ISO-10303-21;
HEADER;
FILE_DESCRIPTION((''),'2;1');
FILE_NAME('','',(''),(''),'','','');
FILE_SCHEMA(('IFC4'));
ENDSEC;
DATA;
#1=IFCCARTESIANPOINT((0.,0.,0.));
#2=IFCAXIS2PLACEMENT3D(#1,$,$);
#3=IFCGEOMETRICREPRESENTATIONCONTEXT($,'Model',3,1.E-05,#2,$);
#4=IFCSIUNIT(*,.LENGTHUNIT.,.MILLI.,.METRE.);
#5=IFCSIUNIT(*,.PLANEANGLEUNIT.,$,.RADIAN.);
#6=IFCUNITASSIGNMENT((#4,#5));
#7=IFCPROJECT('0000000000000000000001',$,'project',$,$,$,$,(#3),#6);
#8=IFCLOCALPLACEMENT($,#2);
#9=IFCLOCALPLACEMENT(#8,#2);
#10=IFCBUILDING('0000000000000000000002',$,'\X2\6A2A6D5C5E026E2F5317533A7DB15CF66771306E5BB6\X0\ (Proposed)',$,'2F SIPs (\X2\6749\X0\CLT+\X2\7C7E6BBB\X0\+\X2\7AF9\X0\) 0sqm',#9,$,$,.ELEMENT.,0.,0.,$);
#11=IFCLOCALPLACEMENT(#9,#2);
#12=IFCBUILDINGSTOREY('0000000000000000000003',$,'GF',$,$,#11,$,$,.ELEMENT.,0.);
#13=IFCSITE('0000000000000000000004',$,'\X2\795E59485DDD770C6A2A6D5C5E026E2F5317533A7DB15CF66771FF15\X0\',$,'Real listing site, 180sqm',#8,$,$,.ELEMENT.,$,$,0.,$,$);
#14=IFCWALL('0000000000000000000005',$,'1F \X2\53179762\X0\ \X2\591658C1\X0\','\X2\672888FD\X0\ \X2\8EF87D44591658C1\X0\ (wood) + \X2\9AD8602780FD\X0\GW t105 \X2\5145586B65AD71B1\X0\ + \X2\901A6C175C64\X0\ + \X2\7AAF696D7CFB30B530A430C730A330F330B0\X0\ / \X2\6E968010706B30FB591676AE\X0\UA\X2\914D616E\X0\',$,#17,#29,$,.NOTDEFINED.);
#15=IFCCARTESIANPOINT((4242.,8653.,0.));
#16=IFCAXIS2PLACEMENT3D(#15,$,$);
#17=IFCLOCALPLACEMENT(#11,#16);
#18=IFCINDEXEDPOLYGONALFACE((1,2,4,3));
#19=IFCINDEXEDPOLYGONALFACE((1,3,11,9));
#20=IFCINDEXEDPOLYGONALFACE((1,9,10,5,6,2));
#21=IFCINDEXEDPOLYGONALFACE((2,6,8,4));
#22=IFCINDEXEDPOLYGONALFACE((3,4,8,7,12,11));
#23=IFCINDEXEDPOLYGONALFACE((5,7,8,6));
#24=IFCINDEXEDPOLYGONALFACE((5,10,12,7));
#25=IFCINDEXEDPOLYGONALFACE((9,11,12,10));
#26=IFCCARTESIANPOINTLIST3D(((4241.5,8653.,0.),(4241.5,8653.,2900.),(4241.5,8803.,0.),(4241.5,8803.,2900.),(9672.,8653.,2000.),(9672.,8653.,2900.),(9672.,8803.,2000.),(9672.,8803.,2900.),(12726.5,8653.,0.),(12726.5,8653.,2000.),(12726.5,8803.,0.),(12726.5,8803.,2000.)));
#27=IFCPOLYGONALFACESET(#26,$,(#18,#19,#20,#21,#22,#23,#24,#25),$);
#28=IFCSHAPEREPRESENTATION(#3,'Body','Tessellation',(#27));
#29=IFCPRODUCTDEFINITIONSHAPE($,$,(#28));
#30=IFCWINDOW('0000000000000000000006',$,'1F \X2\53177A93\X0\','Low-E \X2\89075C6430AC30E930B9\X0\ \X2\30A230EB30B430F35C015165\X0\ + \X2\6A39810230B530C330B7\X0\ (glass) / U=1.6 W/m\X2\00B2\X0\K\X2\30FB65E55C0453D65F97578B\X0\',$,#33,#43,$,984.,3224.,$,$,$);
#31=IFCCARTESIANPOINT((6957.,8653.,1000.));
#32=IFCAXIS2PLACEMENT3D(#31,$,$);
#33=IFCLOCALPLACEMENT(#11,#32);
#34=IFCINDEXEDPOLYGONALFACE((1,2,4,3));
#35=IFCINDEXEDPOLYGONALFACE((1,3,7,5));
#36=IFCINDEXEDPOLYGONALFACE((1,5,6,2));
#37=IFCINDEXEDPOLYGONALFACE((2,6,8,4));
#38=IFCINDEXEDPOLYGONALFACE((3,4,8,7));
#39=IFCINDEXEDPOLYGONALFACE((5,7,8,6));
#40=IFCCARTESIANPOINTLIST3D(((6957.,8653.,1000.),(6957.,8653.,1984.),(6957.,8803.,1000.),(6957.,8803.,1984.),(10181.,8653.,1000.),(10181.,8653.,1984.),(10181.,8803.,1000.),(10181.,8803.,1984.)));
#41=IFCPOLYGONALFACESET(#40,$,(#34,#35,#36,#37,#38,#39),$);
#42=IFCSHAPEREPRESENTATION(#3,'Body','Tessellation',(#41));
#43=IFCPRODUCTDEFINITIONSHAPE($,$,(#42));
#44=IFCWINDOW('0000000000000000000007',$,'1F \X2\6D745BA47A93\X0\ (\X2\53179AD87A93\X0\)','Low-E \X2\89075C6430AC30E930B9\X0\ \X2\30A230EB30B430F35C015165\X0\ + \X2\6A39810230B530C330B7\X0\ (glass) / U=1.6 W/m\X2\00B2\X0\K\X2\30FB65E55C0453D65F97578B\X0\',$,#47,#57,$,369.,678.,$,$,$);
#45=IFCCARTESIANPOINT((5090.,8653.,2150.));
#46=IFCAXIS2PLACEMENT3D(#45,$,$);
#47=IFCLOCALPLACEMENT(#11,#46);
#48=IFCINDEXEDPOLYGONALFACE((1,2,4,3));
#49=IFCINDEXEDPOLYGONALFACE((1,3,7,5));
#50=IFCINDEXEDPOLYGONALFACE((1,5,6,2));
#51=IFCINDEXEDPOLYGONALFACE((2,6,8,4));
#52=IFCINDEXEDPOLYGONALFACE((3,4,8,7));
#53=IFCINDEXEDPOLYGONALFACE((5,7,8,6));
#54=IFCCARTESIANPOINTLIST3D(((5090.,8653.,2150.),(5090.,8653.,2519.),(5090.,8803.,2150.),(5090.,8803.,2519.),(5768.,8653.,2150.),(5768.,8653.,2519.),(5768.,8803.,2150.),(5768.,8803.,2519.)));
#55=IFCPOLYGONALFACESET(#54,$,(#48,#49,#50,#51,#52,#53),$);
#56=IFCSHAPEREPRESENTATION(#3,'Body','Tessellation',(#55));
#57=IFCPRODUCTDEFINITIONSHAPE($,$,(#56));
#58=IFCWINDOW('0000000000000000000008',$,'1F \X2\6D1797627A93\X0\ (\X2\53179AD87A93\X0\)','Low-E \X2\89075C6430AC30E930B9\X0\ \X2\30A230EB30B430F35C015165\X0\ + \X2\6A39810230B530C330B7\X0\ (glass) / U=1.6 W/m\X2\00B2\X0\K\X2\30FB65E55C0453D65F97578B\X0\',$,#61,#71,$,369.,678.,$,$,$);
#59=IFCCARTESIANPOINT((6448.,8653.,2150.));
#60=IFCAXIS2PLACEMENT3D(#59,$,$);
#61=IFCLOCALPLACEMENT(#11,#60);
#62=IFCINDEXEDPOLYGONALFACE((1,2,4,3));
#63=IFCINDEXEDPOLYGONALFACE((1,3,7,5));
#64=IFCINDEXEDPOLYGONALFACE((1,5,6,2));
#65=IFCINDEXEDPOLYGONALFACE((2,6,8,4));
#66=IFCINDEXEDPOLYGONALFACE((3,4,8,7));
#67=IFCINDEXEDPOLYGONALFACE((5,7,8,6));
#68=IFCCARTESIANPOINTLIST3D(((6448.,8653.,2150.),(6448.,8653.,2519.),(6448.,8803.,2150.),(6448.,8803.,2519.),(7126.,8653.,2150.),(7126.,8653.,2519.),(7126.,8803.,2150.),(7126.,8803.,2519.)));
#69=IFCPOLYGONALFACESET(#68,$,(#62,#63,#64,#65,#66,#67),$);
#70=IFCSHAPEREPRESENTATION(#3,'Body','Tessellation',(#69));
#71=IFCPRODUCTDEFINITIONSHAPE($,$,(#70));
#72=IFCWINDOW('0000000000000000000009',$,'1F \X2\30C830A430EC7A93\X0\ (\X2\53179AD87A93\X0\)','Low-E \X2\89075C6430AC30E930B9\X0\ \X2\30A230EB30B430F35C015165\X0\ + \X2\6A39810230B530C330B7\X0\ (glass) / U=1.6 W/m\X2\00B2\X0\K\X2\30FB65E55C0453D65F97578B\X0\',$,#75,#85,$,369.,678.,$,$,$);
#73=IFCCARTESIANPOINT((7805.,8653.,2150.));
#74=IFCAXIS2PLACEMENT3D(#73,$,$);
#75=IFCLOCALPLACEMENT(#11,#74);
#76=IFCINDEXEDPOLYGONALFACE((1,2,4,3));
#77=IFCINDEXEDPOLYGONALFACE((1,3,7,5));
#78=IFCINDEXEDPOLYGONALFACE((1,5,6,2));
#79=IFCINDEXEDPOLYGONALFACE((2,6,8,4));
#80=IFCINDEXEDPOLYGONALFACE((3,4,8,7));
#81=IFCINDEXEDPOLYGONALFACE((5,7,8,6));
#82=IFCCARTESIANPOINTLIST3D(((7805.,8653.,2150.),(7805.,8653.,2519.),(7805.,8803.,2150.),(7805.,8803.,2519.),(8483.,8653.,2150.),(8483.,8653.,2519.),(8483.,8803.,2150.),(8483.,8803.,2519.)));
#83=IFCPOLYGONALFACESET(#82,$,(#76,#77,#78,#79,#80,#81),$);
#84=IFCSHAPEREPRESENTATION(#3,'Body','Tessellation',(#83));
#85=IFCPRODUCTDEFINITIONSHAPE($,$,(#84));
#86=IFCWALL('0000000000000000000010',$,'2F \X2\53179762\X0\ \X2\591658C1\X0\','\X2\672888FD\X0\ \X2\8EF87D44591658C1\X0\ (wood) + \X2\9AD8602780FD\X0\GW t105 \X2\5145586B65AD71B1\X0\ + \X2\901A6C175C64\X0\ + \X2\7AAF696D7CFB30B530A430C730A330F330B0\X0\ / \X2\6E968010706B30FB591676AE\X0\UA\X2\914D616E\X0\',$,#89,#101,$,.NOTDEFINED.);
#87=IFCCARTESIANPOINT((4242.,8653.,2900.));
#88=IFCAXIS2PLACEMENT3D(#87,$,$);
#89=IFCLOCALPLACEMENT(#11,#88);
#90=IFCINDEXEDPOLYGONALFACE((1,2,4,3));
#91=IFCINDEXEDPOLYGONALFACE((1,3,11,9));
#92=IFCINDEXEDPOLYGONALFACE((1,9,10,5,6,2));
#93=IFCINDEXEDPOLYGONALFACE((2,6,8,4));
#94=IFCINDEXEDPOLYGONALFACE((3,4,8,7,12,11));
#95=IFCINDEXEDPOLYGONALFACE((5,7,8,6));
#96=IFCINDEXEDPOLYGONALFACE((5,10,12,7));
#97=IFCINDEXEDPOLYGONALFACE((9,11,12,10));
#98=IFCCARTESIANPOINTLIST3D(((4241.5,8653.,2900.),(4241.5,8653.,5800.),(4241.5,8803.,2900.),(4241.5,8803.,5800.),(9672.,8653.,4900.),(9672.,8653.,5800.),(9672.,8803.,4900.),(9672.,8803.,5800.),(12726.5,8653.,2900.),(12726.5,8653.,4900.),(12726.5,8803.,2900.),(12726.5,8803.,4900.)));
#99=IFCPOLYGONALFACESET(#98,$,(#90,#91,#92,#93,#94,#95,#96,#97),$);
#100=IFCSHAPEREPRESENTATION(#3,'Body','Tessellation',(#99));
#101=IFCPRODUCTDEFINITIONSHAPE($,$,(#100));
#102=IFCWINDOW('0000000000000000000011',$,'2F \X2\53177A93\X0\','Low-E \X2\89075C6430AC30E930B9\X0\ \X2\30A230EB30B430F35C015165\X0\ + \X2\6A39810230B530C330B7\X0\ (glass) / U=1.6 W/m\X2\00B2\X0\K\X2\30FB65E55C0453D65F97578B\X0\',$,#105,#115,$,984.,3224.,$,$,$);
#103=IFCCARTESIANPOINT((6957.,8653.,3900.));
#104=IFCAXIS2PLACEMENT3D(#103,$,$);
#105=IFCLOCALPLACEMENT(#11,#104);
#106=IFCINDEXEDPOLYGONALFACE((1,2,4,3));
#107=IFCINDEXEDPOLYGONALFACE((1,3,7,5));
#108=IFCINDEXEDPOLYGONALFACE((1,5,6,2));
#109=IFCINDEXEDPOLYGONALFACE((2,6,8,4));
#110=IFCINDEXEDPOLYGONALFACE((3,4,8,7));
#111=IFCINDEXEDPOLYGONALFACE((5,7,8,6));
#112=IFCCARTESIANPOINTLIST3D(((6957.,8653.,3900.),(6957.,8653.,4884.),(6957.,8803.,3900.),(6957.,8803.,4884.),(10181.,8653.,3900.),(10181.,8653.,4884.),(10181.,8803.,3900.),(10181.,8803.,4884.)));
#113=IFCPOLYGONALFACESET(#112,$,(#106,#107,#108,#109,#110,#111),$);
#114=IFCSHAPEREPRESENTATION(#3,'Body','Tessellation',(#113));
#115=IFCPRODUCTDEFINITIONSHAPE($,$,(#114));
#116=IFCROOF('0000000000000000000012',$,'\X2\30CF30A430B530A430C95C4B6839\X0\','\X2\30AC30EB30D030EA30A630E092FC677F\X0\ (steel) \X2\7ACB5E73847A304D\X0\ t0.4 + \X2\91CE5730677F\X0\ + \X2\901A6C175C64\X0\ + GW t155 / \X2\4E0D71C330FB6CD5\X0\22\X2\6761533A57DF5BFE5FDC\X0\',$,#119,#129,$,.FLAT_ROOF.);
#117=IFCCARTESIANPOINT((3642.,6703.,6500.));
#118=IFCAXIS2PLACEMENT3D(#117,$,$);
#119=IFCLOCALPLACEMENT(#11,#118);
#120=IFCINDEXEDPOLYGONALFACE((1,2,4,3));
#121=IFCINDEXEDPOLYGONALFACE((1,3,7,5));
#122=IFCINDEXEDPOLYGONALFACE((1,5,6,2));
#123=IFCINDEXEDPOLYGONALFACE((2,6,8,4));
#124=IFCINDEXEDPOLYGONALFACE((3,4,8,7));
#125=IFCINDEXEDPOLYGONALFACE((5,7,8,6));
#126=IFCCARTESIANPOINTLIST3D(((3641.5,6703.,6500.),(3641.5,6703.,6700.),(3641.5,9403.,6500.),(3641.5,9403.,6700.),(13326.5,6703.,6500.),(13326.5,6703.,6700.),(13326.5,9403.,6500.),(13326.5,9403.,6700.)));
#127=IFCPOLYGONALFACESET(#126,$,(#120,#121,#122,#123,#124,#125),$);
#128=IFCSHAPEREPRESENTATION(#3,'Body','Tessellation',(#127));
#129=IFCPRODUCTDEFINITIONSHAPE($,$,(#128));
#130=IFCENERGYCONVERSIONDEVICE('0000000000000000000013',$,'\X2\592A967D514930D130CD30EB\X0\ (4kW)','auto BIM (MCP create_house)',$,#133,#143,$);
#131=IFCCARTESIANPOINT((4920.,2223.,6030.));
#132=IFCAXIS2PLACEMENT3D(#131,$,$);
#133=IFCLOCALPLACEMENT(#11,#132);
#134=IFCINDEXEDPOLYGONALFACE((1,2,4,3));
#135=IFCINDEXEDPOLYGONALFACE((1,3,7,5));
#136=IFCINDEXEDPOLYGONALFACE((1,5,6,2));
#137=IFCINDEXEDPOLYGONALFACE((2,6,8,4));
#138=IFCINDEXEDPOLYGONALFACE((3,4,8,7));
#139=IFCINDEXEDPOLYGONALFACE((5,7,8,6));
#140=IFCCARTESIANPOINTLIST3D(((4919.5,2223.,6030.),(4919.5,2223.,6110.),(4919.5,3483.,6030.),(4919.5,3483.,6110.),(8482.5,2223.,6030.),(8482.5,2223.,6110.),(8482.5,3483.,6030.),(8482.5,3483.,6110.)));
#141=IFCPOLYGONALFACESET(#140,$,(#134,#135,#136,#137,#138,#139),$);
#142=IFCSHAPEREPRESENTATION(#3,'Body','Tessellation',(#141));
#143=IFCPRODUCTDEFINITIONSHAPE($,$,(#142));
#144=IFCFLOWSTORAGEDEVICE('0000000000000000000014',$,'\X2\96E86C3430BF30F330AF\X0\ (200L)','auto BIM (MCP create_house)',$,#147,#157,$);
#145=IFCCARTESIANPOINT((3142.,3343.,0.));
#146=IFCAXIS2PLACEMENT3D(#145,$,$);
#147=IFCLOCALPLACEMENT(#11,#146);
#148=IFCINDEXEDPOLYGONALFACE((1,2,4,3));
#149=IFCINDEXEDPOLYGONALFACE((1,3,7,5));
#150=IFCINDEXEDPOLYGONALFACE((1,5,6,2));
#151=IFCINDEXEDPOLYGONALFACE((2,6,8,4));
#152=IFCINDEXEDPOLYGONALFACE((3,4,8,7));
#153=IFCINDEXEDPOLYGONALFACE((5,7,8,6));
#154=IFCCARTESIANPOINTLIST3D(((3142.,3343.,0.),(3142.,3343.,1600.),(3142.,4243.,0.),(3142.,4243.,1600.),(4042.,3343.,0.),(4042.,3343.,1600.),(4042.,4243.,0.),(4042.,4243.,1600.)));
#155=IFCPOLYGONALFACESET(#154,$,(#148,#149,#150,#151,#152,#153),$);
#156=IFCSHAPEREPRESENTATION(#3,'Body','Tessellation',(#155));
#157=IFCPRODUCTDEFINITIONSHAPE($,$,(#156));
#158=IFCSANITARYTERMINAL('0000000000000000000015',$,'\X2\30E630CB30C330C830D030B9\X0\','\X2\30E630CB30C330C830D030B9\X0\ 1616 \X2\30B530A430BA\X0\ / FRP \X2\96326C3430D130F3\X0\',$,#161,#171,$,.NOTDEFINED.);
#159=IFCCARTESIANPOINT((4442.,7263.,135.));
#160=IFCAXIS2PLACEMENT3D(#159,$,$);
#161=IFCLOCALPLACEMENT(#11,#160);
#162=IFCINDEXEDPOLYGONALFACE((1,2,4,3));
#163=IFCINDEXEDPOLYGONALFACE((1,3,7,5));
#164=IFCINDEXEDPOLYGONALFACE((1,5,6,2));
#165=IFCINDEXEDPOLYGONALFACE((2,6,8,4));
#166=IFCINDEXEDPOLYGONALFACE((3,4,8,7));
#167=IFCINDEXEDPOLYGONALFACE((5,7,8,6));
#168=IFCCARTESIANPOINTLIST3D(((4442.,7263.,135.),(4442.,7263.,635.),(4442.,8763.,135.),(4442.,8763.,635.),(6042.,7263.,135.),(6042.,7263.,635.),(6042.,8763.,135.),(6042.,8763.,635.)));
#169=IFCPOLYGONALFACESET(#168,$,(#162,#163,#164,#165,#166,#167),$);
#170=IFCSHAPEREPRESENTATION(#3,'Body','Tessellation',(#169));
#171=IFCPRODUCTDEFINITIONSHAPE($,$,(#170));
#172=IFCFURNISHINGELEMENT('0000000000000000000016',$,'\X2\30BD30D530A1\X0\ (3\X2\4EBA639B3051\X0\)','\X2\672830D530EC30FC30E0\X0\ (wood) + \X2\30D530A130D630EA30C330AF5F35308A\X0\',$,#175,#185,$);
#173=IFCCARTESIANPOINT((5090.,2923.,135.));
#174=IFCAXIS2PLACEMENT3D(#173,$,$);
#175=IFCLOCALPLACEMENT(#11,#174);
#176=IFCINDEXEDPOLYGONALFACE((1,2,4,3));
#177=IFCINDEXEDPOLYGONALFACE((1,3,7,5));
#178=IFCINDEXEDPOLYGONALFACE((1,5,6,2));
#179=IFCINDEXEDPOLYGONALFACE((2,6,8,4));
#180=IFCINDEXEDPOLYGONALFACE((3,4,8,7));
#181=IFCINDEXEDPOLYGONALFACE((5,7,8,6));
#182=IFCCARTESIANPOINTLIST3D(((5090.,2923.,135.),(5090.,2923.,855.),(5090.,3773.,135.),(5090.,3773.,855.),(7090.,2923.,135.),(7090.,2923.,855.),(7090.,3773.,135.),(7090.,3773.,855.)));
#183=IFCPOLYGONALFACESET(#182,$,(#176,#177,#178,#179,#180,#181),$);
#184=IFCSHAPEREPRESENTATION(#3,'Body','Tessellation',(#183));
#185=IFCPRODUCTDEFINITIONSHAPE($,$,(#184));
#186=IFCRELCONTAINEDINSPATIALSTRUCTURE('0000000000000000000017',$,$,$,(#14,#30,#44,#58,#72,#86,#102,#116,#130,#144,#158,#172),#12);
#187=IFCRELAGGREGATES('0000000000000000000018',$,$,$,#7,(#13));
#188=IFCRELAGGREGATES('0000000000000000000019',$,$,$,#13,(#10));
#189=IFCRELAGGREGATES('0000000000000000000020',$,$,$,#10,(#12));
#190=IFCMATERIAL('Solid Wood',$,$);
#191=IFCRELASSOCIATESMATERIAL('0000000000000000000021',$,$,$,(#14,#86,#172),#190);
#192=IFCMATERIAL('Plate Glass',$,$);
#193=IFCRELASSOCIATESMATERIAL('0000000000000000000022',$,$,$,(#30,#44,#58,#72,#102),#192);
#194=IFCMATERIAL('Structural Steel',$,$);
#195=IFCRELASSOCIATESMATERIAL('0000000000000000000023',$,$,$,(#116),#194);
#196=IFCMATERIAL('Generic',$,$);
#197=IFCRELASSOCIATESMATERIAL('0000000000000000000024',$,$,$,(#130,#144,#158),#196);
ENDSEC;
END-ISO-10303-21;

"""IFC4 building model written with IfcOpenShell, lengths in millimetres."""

from ifc_helpers import new_model, si_unit, frame, frame_2d, origin, place, context, project, spatial, rectangle, extrude, material, element, fill, save


model = new_model("IFC4")

# Units and contexts
model_context = context("Model", 3, precision=1e-05, world=origin())
ifc_project = project(units=[si_unit("LENGTHUNIT", "METRE", prefix="MILLI"), si_unit("PLANEANGLEUNIT", "RADIAN")], contexts=[model_context])

# Site, building, storey
site_placement = place(None, origin())
site = spatial("IfcSite", under=ifc_project, at=site_placement, Name="神奈川県横浜市港北区綱島東５", ObjectType="Real listing site, 180sqm", CompositionType="ELEMENT", RefElevation=0.0)
building_placement = place(site_placement, origin())
building = spatial("IfcBuilding", under=site, at=building_placement, Name="横浜市港北区綱島東の家 (Proposed)", ObjectType="2F SIPs (杉CLT+籾殻+竹) 0sqm", CompositionType="ELEMENT", ElevationOfRefHeight=0.0, ElevationOfTerrain=0.0)
storey_placement = place(building_placement, origin())
storey = spatial("IfcBuildingStorey", under=building, at=storey_placement, Name="GF", CompositionType="ELEMENT", Elevation=0.0)

# Wall, openings, windows
ifc_material_1 = material(Name="Solid Wood")
wall_1_placement = place(storey_placement, frame((4242.0, 8653.0, 0.0)))
wall_1 = element("IfcWall", 1, at=wall_1_placement, inside=storey, material=ifc_material_1, Name="1F 北面 外壁", Description="木製 軸組外壁 (wood) + 高性能GW t105 充填断熱 + 通気層 + 窯業系サイディング / 準耐火・外皮UA配慮", PredefinedType="NOTDEFINED", context=model_context, shape_type="SweptSolid", body=[
    extrude(rectangle(XDim=8485.0, YDim=150.0, at=frame_2d((4242.0, 75.0))), frame((4242.0, 8653.0, 0.0)), (0.0, 0.0, 1.0), 2900.0),
])
opening_1_placement = place(storey_placement, frame((6957.0, 8653.0, 1000.0)))
opening_1 = element("IfcOpeningElement", 2, at=opening_1_placement, cuts=wall_1, PredefinedType="NOTDEFINED", context=model_context, shape_type="SweptSolid", body=[
    extrude(rectangle(XDim=3224.0, YDim=150.0, at=frame_2d((1612.0, 75.0))), frame((6957.0, 8653.0, 1000.0)), (0.0, 0.0, 1.0), 984.0),
])
opening_2_placement = place(storey_placement, frame((5090.0, 8653.0, 2150.0)))
opening_2 = element("IfcOpeningElement", 3, at=opening_2_placement, cuts=wall_1, PredefinedType="NOTDEFINED", context=model_context, shape_type="SweptSolid", body=[
    extrude(rectangle(XDim=678.0, YDim=150.0, at=frame_2d((339.0, 75.0))), frame((5090.0, 8653.0, 2150.0)), (0.0, 0.0, 1.0), 369.0),
])
opening_3_placement = place(storey_placement, frame((6448.0, 8653.0, 2150.0)))
opening_3 = element("IfcOpeningElement", 4, at=opening_3_placement, cuts=wall_1, PredefinedType="NOTDEFINED", context=model_context, shape_type="SweptSolid", body=[
    extrude(rectangle(XDim=678.0, YDim=150.0, at=frame_2d((339.0, 75.0))), frame((6448.0, 8653.0, 2150.0)), (0.0, 0.0, 1.0), 369.0),
])
opening_4_placement = place(storey_placement, frame((7805.0, 8653.0, 2150.0)))
opening_4 = element("IfcOpeningElement", 5, at=opening_4_placement, cuts=wall_1, PredefinedType="NOTDEFINED", context=model_context, shape_type="SweptSolid", body=[
    extrude(rectangle(XDim=678.0, YDim=150.0, at=frame_2d((339.0, 75.0))), frame((7805.0, 8653.0, 2150.0)), (0.0, 0.0, 1.0), 369.0),
])
ifc_material_2 = material(Name="Plate Glass")
window_1_placement = place(storey_placement, frame((6957.0, 8653.0, 1000.0)))
window_1 = element("IfcWindow", 6, at=window_1_placement, inside=storey, material=ifc_material_2, Name="1F 北窓", Description="Low-E 複層ガラス アルゴン封入 + 樹脂サッシ (glass) / U=1.6 W/m²K・日射取得型", OverallHeight=984.0, OverallWidth=3224.0, context=model_context, shape_type="SweptSolid", body=[
    extrude(rectangle(XDim=3224.0, YDim=150.0, at=frame_2d((1612.0, 75.0))), frame((6957.0, 8653.0, 1000.0)), (0.0, 0.0, 1.0), 984.0),
])
fill(opening_1, window_1)
window_2_placement = place(storey_placement, frame((5090.0, 8653.0, 2150.0)))
window_2 = element("IfcWindow", 7, at=window_2_placement, inside=storey, material=ifc_material_2, Name="1F 浴室窓 (北高窓)", Description="Low-E 複層ガラス アルゴン封入 + 樹脂サッシ (glass) / U=1.6 W/m²K・日射取得型", OverallHeight=369.0, OverallWidth=678.0, context=model_context, shape_type="SweptSolid", body=[
    extrude(rectangle(XDim=678.0, YDim=150.0, at=frame_2d((339.0, 75.0))), frame((5090.0, 8653.0, 2150.0)), (0.0, 0.0, 1.0), 369.0),
])
fill(opening_2, window_2)
window_3_placement = place(storey_placement, frame((6448.0, 8653.0, 2150.0)))
window_3 = element("IfcWindow", 8, at=window_3_placement, inside=storey, material=ifc_material_2, Name="1F 洗面窓 (北高窓)", Description="Low-E 複層ガラス アルゴン封入 + 樹脂サッシ (glass) / U=1.6 W/m²K・日射取得型", OverallHeight=369.0, OverallWidth=678.0, context=model_context, shape_type="SweptSolid", body=[
    extrude(rectangle(XDim=678.0, YDim=150.0, at=frame_2d((339.0, 75.0))), frame((6448.0, 8653.0, 2150.0)), (0.0, 0.0, 1.0), 369.0),
])
fill(opening_3, window_3)
window_4_placement = place(storey_placement, frame((7805.0, 8653.0, 2150.0)))
window_4 = element("IfcWindow", 9, at=window_4_placement, inside=storey, material=ifc_material_2, Name="1F トイレ窓 (北高窓)", Description="Low-E 複層ガラス アルゴン封入 + 樹脂サッシ (glass) / U=1.6 W/m²K・日射取得型", OverallHeight=369.0, OverallWidth=678.0, context=model_context, shape_type="SweptSolid", body=[
    extrude(rectangle(XDim=678.0, YDim=150.0, at=frame_2d((339.0, 75.0))), frame((7805.0, 8653.0, 2150.0)), (0.0, 0.0, 1.0), 369.0),
])
fill(opening_4, window_4)

# Wall, opening, window
wall_2_placement = place(storey_placement, frame((4242.0, 8653.0, 2900.0)))
wall_2 = element("IfcWall", 10, at=wall_2_placement, inside=storey, material=ifc_material_1, Name="2F 北面 外壁", Description="木製 軸組外壁 (wood) + 高性能GW t105 充填断熱 + 通気層 + 窯業系サイディング / 準耐火・外皮UA配慮", PredefinedType="NOTDEFINED", context=model_context, shape_type="SweptSolid", body=[
    extrude(rectangle(XDim=8485.0, YDim=150.0, at=frame_2d((4242.0, 75.0))), frame((4242.0, 8653.0, 2900.0)), (0.0, 0.0, 1.0), 2900.0),
])
opening_5_placement = place(storey_placement, frame((6957.0, 8653.0, 3900.0)))
opening_5 = element("IfcOpeningElement", 11, at=opening_5_placement, cuts=wall_2, PredefinedType="NOTDEFINED", context=model_context, shape_type="SweptSolid", body=[
    extrude(rectangle(XDim=3224.0, YDim=150.0, at=frame_2d((1612.0, 75.0))), frame((6957.0, 8653.0, 3900.0)), (0.0, 0.0, 1.0), 984.0),
])
window_5_placement = place(storey_placement, frame((6957.0, 8653.0, 3900.0)))
window_5 = element("IfcWindow", 12, at=window_5_placement, inside=storey, material=ifc_material_2, Name="2F 北窓", Description="Low-E 複層ガラス アルゴン封入 + 樹脂サッシ (glass) / U=1.6 W/m²K・日射取得型", OverallHeight=984.0, OverallWidth=3224.0, context=model_context, shape_type="SweptSolid", body=[
    extrude(rectangle(XDim=3224.0, YDim=150.0, at=frame_2d((1612.0, 75.0))), frame((6957.0, 8653.0, 3900.0)), (0.0, 0.0, 1.0), 984.0),
])
fill(opening_5, window_5)

# Roof
ifc_material_3 = material(Name="Structural Steel")
roof_placement = place(storey_placement, frame((3642.0, 6703.0, 6500.0)))
element("IfcRoof", 13, at=roof_placement, inside=storey, material=ifc_material_3, Name="ハイサイド屋根", Description="ガルバリウム鋼板 (steel) 立平葺き t0.4 + 野地板 + 通気層 + GW t155 / 不燃・法22条区域対応", PredefinedType="FLAT_ROOF", context=model_context, shape_type="SweptSolid", body=[
    extrude(rectangle(XDim=9685.0, YDim=2700.0, at=frame_2d((4842.0, 1350.0))), frame((3642.0, 6703.0, 6500.0)), (0.0, 0.0, 1.0), 200.0),
])

# Energy conversion device
ifc_material_4 = material(Name="Generic")
energy_conversion_device_placement = place(storey_placement, frame((4920.0, 2223.0, 6030.0)))
element("IfcEnergyConversionDevice", 14, at=energy_conversion_device_placement, inside=storey, material=ifc_material_4, Name="太陽光パネル (4kW)", Description="auto BIM (MCP create_house)", context=model_context, shape_type="SweptSolid", body=[
    extrude(rectangle(XDim=3563.0, YDim=1260.0, at=frame_2d((1781.0, 630.0))), frame((4920.0, 2223.0, 6030.0)), (0.0, 0.0, 1.0), 80.0),
])

# Flow storage device
flow_storage_device_placement = place(storey_placement, frame((3142.0, 3343.0, 0.0)))
element("IfcFlowStorageDevice", 15, at=flow_storage_device_placement, inside=storey, material=ifc_material_4, Name="雨水タンク (200L)", Description="auto BIM (MCP create_house)", context=model_context, shape_type="SweptSolid", body=[
    extrude(rectangle(XDim=900.0, YDim=900.0, at=frame_2d((450.0, 450.0))), frame((3142.0, 3343.0, 0.0)), (0.0, 0.0, 1.0), 1600.0),
])

# Sanitary terminal
sanitary_terminal_placement = place(storey_placement, frame((4442.0, 7263.0, 135.0)))
element("IfcSanitaryTerminal", 16, at=sanitary_terminal_placement, inside=storey, material=ifc_material_4, Name="ユニットバス", Description="ユニットバス 1616 サイズ / FRP 防水パン", PredefinedType="NOTDEFINED", context=model_context, shape_type="SweptSolid", body=[
    extrude(rectangle(XDim=1600.0, YDim=1500.0, at=frame_2d((800.0, 750.0))), frame((4442.0, 7263.0, 135.0)), (0.0, 0.0, 1.0), 500.0),
])

# Furnishing element
furnishing_1_placement = place(storey_placement, frame((5090.0, 2923.0, 135.0)))
element("IfcFurnishingElement", 17, at=furnishing_1_placement, inside=storey, material=ifc_material_1, Name="ソファ (3人掛け)", Description="木フレーム (wood) + ファブリック張り", context=model_context, shape_type="SweptSolid", body=[
    extrude(rectangle(XDim=2000.0, YDim=850.0, at=frame_2d((1000.0, 425.0))), frame((5090.0, 2923.0, 135.0)), (0.0, 0.0, 1.0), 720.0),
])

save(model, "model.ifc")
